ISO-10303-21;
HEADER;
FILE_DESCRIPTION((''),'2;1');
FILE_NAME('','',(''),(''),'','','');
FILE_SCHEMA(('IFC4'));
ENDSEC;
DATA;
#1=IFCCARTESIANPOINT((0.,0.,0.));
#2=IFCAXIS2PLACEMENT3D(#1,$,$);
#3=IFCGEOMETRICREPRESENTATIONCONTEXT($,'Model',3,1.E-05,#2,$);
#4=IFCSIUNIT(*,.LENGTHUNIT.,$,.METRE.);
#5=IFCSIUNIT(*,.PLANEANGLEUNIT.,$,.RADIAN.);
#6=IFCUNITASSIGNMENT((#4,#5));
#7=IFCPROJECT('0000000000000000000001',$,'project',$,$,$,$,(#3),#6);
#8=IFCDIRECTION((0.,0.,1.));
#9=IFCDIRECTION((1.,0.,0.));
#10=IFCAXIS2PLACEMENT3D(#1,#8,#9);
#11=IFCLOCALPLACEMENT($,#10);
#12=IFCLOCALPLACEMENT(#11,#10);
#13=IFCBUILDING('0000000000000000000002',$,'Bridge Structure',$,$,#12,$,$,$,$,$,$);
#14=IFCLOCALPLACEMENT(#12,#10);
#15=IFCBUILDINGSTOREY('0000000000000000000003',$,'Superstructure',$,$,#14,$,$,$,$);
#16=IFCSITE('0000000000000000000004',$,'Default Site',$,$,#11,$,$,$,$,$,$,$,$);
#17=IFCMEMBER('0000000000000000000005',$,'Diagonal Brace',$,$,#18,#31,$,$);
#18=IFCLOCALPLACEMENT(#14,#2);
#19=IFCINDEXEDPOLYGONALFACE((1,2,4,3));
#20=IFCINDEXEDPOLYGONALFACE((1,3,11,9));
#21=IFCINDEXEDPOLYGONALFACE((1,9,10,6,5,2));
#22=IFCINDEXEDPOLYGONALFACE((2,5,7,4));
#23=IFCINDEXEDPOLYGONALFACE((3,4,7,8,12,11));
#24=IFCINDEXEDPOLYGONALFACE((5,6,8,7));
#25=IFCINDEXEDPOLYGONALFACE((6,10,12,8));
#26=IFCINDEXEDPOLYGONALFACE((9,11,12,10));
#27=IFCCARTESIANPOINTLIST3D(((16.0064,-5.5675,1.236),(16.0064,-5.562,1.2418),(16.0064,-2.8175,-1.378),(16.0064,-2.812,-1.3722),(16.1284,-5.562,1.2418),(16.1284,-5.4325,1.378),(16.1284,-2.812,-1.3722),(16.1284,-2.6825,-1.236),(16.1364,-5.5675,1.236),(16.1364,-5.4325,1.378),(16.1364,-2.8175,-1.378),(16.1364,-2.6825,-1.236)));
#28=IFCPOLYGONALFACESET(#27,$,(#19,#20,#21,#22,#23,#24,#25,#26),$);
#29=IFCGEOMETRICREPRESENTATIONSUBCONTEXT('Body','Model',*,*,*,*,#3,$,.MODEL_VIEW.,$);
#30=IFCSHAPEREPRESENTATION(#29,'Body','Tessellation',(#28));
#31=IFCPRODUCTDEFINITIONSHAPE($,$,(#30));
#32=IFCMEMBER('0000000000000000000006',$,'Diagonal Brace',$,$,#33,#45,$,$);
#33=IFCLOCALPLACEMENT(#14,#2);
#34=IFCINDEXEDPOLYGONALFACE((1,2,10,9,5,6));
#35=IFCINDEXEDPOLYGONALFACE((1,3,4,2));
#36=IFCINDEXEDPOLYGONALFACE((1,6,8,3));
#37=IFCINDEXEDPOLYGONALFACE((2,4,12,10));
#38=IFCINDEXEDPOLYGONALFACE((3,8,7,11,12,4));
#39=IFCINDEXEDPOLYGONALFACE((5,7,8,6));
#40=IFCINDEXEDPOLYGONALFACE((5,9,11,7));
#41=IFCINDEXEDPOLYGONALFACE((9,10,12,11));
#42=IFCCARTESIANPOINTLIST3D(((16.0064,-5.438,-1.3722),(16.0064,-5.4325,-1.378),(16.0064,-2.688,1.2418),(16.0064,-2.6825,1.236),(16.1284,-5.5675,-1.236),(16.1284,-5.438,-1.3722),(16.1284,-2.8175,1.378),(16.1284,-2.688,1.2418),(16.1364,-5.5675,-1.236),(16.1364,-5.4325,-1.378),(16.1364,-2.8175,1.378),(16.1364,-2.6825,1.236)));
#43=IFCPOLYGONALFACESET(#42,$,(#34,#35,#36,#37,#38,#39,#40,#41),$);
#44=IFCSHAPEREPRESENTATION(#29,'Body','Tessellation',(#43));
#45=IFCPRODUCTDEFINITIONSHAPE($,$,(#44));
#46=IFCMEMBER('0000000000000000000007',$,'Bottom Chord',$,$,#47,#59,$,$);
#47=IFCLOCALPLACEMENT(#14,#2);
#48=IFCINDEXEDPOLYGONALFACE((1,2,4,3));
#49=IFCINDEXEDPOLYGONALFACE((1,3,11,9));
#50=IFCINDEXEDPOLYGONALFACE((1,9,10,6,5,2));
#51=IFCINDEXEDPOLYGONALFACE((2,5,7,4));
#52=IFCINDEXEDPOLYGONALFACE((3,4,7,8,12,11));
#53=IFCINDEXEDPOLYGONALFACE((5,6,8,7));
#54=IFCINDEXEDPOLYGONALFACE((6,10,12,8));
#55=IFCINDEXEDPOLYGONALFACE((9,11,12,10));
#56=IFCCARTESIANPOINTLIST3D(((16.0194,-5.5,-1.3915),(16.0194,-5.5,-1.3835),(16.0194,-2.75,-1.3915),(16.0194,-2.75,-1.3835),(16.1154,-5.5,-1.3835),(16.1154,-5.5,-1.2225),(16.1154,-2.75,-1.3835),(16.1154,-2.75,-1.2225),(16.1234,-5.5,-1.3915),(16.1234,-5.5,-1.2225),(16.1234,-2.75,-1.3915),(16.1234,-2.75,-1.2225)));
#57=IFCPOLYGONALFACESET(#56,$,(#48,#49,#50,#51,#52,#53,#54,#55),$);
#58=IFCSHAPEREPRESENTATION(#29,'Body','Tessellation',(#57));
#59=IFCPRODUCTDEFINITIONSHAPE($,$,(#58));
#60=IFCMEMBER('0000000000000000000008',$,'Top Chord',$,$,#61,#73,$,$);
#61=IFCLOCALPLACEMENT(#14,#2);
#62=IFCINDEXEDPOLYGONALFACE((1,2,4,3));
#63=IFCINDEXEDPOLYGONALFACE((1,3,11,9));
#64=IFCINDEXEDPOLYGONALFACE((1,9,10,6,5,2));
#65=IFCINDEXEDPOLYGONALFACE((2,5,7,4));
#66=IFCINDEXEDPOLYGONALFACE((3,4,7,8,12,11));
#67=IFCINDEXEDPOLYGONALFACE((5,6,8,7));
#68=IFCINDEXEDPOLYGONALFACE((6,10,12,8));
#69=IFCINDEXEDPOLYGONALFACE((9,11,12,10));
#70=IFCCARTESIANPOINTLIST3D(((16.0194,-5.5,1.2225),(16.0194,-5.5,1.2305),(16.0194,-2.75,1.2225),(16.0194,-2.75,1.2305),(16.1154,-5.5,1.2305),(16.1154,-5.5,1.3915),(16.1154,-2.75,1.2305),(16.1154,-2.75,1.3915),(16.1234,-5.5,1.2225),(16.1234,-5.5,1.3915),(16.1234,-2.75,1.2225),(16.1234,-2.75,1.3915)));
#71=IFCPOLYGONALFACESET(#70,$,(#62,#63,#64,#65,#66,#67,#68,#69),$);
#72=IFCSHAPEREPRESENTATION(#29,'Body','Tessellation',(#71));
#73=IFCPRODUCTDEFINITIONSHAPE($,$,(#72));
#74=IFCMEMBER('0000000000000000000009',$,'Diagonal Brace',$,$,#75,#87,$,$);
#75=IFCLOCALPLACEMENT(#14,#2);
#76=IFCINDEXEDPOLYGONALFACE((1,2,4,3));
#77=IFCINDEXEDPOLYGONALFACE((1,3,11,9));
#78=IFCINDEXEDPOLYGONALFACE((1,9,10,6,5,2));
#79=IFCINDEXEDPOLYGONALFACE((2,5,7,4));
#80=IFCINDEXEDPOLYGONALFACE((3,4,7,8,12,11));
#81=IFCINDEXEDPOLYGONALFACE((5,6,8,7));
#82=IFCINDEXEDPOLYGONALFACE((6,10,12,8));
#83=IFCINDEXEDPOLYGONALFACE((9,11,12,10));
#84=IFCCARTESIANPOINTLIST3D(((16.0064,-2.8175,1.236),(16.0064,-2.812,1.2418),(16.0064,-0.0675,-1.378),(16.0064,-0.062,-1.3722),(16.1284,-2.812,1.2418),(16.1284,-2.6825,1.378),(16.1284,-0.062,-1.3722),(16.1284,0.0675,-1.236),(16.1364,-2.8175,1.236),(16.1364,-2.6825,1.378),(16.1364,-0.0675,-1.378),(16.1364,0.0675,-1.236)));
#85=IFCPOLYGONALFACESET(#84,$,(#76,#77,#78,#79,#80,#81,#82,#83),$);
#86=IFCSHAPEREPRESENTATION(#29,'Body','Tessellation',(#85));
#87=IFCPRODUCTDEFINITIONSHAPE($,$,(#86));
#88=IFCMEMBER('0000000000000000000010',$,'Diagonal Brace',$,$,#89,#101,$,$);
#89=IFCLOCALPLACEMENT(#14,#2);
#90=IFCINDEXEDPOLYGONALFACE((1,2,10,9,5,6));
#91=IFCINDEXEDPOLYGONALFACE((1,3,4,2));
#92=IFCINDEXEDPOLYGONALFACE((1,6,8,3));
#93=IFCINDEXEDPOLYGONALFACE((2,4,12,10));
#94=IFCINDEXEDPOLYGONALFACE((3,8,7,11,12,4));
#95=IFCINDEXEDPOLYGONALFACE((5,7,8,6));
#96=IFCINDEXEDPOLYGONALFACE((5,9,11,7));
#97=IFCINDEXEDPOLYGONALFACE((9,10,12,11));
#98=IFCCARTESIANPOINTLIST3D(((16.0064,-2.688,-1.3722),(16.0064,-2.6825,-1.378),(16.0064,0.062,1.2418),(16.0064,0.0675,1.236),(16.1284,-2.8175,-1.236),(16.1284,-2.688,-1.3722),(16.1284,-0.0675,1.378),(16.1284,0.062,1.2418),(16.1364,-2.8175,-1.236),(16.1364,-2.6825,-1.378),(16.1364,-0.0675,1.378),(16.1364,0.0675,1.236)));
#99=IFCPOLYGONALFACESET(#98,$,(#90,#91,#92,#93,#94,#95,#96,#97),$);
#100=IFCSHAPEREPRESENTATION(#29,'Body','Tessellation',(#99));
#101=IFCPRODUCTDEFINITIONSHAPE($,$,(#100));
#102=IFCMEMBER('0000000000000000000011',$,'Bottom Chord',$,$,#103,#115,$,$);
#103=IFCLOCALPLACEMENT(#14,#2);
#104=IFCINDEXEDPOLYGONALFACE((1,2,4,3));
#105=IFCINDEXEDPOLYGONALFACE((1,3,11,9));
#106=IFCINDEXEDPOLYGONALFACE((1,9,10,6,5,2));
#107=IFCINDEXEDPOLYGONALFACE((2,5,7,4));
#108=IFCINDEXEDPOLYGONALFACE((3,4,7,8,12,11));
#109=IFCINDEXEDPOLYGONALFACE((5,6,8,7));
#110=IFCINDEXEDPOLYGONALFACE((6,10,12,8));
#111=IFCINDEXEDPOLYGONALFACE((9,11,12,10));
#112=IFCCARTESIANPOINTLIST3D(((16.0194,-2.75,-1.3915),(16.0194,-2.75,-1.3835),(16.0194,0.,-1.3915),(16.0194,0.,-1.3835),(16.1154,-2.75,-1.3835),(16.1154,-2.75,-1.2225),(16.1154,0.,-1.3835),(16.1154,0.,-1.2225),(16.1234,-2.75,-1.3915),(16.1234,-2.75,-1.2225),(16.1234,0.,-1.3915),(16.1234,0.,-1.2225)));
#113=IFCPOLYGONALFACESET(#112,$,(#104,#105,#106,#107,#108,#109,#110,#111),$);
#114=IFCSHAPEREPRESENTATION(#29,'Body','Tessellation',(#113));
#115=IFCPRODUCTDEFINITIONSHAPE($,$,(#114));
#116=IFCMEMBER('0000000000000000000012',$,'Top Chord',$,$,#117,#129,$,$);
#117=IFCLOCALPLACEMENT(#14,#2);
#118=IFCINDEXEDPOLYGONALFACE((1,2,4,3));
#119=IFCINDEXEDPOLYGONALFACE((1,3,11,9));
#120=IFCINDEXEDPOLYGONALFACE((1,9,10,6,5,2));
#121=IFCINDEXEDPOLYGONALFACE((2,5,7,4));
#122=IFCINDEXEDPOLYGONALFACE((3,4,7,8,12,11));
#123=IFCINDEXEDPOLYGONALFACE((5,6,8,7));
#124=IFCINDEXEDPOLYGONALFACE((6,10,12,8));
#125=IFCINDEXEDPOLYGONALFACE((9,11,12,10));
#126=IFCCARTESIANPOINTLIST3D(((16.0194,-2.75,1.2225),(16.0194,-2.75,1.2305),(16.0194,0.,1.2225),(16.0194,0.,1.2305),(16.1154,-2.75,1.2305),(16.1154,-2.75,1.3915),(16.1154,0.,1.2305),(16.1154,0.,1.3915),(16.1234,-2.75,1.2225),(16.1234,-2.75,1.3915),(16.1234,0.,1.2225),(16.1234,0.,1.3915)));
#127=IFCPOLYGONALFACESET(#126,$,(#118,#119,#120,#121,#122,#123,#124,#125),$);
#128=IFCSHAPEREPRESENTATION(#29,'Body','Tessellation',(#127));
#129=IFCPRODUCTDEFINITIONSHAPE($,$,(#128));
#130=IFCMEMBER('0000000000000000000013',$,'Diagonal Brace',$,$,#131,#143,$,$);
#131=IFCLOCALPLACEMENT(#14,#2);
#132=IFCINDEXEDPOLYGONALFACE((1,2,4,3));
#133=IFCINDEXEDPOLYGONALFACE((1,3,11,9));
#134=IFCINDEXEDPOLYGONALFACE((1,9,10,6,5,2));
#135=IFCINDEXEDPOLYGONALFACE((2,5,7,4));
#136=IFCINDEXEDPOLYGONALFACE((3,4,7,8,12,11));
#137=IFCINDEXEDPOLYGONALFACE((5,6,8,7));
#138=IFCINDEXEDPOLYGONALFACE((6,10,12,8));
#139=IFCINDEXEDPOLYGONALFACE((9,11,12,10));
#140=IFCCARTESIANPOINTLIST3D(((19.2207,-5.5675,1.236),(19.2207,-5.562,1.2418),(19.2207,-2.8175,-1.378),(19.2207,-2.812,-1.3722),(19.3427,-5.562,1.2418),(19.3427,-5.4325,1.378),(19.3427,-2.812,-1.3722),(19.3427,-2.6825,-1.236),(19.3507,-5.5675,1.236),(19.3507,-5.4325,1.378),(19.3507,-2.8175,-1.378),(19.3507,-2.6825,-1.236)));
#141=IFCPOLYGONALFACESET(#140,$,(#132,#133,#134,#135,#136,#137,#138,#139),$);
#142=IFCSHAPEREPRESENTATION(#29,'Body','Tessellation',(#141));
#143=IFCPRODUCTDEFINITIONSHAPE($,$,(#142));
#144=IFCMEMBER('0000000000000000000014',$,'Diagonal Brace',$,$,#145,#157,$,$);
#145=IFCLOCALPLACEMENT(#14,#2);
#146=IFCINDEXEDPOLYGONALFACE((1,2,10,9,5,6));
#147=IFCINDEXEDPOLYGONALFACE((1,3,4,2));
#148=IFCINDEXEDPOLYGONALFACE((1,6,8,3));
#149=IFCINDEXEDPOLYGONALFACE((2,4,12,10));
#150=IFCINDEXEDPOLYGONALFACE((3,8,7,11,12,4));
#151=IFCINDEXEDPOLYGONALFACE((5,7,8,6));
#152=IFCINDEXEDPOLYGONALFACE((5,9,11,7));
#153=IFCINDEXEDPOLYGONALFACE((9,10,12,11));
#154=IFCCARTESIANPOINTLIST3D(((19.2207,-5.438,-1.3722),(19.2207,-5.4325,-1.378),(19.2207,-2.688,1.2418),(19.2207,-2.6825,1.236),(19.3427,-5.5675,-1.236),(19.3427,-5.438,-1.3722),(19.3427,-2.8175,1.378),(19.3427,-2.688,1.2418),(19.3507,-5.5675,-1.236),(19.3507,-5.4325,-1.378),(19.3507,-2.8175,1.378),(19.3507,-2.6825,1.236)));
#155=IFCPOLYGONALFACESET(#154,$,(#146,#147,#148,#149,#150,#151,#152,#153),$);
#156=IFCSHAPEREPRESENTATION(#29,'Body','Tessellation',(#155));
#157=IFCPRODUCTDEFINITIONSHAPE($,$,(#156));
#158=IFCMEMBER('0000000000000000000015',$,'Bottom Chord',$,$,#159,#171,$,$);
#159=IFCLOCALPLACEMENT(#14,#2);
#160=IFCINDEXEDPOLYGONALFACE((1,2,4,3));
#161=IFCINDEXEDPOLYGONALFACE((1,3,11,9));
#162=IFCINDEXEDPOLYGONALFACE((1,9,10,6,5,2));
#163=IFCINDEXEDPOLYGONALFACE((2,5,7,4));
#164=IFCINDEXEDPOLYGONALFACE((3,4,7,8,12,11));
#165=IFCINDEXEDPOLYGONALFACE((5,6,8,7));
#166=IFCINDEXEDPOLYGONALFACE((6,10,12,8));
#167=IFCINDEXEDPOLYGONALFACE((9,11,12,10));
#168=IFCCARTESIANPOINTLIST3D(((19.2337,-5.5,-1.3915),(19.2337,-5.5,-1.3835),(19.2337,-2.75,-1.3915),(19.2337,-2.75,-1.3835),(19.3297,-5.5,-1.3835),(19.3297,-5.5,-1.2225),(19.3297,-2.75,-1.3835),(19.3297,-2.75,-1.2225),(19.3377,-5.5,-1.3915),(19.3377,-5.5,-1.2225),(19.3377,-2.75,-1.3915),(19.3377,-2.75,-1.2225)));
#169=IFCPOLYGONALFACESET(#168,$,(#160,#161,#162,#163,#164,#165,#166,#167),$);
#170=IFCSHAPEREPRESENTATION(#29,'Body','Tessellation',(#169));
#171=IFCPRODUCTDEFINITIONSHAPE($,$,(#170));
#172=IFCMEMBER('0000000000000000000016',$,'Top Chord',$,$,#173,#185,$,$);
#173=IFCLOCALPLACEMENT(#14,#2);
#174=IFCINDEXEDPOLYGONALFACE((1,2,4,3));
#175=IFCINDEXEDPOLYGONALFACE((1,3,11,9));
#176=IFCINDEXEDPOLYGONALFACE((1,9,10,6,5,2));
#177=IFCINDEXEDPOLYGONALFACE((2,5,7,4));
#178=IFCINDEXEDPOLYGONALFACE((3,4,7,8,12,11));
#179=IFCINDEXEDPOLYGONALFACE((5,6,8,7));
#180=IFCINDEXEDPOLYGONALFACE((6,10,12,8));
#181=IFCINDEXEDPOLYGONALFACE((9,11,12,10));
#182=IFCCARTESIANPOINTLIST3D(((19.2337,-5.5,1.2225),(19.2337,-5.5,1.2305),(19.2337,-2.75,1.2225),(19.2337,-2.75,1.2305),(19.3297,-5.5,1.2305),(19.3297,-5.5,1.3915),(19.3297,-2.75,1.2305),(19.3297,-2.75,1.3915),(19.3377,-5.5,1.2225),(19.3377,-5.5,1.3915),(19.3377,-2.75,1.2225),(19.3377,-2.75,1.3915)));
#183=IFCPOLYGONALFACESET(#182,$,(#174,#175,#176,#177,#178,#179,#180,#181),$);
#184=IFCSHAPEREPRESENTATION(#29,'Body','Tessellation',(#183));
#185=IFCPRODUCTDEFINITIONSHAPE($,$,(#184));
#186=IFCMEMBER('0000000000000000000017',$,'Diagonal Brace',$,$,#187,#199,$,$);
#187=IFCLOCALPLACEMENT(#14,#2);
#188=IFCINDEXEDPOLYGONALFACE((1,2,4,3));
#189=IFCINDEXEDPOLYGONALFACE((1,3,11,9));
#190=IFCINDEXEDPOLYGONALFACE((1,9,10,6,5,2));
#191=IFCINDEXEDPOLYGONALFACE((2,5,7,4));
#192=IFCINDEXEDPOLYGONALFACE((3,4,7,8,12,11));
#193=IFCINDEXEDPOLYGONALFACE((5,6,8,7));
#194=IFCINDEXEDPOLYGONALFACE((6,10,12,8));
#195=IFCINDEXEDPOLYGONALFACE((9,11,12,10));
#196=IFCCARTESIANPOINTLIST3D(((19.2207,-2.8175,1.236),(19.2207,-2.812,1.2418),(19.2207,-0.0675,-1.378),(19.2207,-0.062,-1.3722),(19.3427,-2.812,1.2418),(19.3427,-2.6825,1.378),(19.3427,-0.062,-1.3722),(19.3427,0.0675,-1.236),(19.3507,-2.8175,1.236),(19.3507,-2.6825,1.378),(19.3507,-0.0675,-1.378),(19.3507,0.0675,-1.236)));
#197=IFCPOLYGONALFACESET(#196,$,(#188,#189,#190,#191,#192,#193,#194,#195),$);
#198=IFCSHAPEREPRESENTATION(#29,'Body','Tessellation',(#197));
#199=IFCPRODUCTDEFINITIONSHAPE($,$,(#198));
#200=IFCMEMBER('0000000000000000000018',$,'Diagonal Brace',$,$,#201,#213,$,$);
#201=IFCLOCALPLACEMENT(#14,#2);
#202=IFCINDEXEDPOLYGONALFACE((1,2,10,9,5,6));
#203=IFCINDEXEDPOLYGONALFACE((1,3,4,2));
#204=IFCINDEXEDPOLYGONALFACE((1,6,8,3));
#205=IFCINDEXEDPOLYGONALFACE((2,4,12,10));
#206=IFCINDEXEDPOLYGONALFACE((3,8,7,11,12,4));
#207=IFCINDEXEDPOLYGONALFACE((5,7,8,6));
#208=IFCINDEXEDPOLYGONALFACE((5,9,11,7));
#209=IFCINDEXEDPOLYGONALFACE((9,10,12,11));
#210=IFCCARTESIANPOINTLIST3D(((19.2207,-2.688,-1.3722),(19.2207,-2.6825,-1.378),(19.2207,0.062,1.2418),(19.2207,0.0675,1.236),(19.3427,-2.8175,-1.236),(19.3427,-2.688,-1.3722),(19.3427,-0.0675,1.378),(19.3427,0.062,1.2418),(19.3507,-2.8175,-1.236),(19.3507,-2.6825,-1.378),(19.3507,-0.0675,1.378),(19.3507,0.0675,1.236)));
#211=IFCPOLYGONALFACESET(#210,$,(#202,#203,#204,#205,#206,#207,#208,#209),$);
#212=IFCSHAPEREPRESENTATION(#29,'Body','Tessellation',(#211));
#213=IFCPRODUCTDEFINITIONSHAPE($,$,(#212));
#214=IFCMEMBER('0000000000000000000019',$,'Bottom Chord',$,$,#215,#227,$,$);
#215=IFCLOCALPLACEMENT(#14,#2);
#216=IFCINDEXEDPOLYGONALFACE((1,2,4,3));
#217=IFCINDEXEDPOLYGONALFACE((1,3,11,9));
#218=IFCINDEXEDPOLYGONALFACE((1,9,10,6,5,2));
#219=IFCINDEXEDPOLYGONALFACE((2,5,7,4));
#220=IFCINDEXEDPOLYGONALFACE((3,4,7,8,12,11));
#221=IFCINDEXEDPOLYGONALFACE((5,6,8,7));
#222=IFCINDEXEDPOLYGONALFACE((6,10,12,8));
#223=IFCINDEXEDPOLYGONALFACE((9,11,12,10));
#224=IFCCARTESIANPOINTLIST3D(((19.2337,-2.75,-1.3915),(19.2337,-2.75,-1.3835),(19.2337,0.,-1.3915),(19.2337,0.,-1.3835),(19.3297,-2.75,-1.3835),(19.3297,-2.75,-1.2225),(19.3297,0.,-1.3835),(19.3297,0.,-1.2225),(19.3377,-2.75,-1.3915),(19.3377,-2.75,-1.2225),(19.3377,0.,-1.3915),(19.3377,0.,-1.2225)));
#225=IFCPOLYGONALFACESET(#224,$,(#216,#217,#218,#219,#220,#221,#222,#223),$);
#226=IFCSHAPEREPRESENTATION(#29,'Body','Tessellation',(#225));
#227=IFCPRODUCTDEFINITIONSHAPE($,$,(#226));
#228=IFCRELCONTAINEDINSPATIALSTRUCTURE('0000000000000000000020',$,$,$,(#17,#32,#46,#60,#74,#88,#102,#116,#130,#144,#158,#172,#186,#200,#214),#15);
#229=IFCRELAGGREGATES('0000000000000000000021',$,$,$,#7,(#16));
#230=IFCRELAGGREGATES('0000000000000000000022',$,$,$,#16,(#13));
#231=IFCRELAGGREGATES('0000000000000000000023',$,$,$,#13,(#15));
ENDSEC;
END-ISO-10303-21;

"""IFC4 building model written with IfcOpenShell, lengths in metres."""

from ifc_helpers import new_model, si_unit, frame, origin, origin_with_axes, origin_2d_with_axis, place, context, subcontext, project, spatial, l_section, extrude, element, save


model = new_model("IFC4")

# Units and contexts
model_context = context("Model", 3, precision=1e-05, world=origin())
body_context = subcontext(model_context, "Body", "Model", "MODEL_VIEW")
ifc_project = project(units=[si_unit("LENGTHUNIT", "METRE"), si_unit("PLANEANGLEUNIT", "RADIAN")], contexts=[model_context])

# Site, building, storey
site_placement = place(None, origin_with_axes())
site = spatial("IfcSite", under=ifc_project, at=site_placement, Name="Default Site")
building_placement = place(site_placement, origin_with_axes())
building = spatial("IfcBuilding", under=site, at=building_placement, Name="Bridge Structure")
storey_placement = place(building_placement, origin_with_axes())
storey = spatial("IfcBuildingStorey", under=building, at=storey_placement, Name="Superstructure")

# Members
for number, where, z_axis, x_axis, name in (
    (1, (16.0714, -5.5, 1.307), (0.0, 0.724802, -0.688957), (-1.0, 0.0, 0.0), "Diagonal Brace"),
    (2, (16.0714, -5.5, -1.307), (0.0, 0.724802, 0.688957), (-1.0, 0.0, 0.0), "Diagonal Brace"),
):
    element("IfcMember", number, at=place(storey_placement, frame(where, z_axis=z_axis, x_axis=x_axis)), inside=storey, Name=name, context=body_context, shape_type="SweptSolid", body=[
        extrude(l_section(Depth=0.196, Width=0.13, Thickness=0.008, at=origin_2d_with_axis()), origin_with_axes(), (0.0, 0.0, 1.0), 3.7941),
    ])
for number, where, z_axis, x_axis, name in (
    (3, (16.0714, -5.5, -1.307), (0.0, 1.0, 0.0), (-1.0, 0.0, 0.0), "Bottom Chord"),
    (4, (16.0714, -5.5, 1.307), (0.0, 1.0, 0.0), (-1.0, 0.0, 0.0), "Top Chord"),
):
    element("IfcMember", number, at=place(storey_placement, frame(where, z_axis=z_axis, x_axis=x_axis)), inside=storey, Name=name, context=body_context, shape_type="SweptSolid", body=[
        extrude(l_section(Depth=0.169, Width=0.104, Thickness=0.008, at=origin_2d_with_axis()), origin_with_axes(), (0.0, 0.0, 1.0), 2.75),
    ])
for number, where, z_axis, x_axis, name in (
    (5, (16.0714, -2.75, 1.307), (0.0, 0.724802, -0.688957), (-1.0, 0.0, 0.0), "Diagonal Brace"),
    (6, (16.0714, -2.75, -1.307), (0.0, 0.724802, 0.688957), (-1.0, 0.0, 0.0), "Diagonal Brace"),
):
    element("IfcMember", number, at=place(storey_placement, frame(where, z_axis=z_axis, x_axis=x_axis)), inside=storey, Name=name, context=body_context, shape_type="SweptSolid", body=[
        extrude(l_section(Depth=0.196, Width=0.13, Thickness=0.008, at=origin_2d_with_axis()), origin_with_axes(), (0.0, 0.0, 1.0), 3.7941),
    ])
for number, where, z_axis, x_axis, name in (
    (7, (16.0714, -2.75, -1.307), (0.0, 1.0, 0.0), (-1.0, 0.0, 0.0), "Bottom Chord"),
    (8, (16.0714, -2.75, 1.307), (0.0, 1.0, 0.0), (-1.0, 0.0, 0.0), "Top Chord"),
):
    element("IfcMember", number, at=place(storey_placement, frame(where, z_axis=z_axis, x_axis=x_axis)), inside=storey, Name=name, context=body_context, shape_type="SweptSolid", body=[
        extrude(l_section(Depth=0.169, Width=0.104, Thickness=0.008, at=origin_2d_with_axis()), origin_with_axes(), (0.0, 0.0, 1.0), 2.75),
    ])
for number, where, z_axis, x_axis, name in (
    (9, (19.2857, -5.5, 1.307), (0.0, 0.724802, -0.688957), (-1.0, 0.0, 0.0), "Diagonal Brace"),
    (10, (19.2857, -5.5, -1.307), (0.0, 0.724802, 0.688957), (-1.0, 0.0, 0.0), "Diagonal Brace"),
):
    element("IfcMember", number, at=place(storey_placement, frame(where, z_axis=z_axis, x_axis=x_axis)), inside=storey, Name=name, context=body_context, shape_type="SweptSolid", body=[
        extrude(l_section(Depth=0.196, Width=0.13, Thickness=0.008, at=origin_2d_with_axis()), origin_with_axes(), (0.0, 0.0, 1.0), 3.7941),
    ])
for number, where, z_axis, x_axis, name in (
    (11, (19.2857, -5.5, -1.307), (0.0, 1.0, 0.0), (-1.0, 0.0, 0.0), "Bottom Chord"),
    (12, (19.2857, -5.5, 1.307), (0.0, 1.0, 0.0), (-1.0, 0.0, 0.0), "Top Chord"),
):
    element("IfcMember", number, at=place(storey_placement, frame(where, z_axis=z_axis, x_axis=x_axis)), inside=storey, Name=name, context=body_context, shape_type="SweptSolid", body=[
        extrude(l_section(Depth=0.169, Width=0.104, Thickness=0.008, at=origin_2d_with_axis()), origin_with_axes(), (0.0, 0.0, 1.0), 2.75),
    ])
for number, where, z_axis, x_axis, name in (
    (13, (19.2857, -2.75, 1.307), (0.0, 0.724802, -0.688957), (-1.0, 0.0, 0.0), "Diagonal Brace"),
    (14, (19.2857, -2.75, -1.307), (0.0, 0.724802, 0.688957), (-1.0, 0.0, 0.0), "Diagonal Brace"),
):
    element("IfcMember", number, at=place(storey_placement, frame(where, z_axis=z_axis, x_axis=x_axis)), inside=storey, Name=name, context=body_context, shape_type="SweptSolid", body=[
        extrude(l_section(Depth=0.196, Width=0.13, Thickness=0.008, at=origin_2d_with_axis()), origin_with_axes(), (0.0, 0.0, 1.0), 3.7941),
    ])
for number, where, z_axis, x_axis, name in (
    (15, (19.2857, -2.75, -1.307), (0.0, 1.0, 0.0), (-1.0, 0.0, 0.0), "Bottom Chord"),
):
    element("IfcMember", number, at=place(storey_placement, frame(where, z_axis=z_axis, x_axis=x_axis)), inside=storey, Name=name, context=body_context, shape_type="SweptSolid", body=[
        extrude(l_section(Depth=0.169, Width=0.104, Thickness=0.008, at=origin_2d_with_axis()), origin_with_axes(), (0.0, 0.0, 1.0), 2.75),
    ])

save(model, "model.ifc")
